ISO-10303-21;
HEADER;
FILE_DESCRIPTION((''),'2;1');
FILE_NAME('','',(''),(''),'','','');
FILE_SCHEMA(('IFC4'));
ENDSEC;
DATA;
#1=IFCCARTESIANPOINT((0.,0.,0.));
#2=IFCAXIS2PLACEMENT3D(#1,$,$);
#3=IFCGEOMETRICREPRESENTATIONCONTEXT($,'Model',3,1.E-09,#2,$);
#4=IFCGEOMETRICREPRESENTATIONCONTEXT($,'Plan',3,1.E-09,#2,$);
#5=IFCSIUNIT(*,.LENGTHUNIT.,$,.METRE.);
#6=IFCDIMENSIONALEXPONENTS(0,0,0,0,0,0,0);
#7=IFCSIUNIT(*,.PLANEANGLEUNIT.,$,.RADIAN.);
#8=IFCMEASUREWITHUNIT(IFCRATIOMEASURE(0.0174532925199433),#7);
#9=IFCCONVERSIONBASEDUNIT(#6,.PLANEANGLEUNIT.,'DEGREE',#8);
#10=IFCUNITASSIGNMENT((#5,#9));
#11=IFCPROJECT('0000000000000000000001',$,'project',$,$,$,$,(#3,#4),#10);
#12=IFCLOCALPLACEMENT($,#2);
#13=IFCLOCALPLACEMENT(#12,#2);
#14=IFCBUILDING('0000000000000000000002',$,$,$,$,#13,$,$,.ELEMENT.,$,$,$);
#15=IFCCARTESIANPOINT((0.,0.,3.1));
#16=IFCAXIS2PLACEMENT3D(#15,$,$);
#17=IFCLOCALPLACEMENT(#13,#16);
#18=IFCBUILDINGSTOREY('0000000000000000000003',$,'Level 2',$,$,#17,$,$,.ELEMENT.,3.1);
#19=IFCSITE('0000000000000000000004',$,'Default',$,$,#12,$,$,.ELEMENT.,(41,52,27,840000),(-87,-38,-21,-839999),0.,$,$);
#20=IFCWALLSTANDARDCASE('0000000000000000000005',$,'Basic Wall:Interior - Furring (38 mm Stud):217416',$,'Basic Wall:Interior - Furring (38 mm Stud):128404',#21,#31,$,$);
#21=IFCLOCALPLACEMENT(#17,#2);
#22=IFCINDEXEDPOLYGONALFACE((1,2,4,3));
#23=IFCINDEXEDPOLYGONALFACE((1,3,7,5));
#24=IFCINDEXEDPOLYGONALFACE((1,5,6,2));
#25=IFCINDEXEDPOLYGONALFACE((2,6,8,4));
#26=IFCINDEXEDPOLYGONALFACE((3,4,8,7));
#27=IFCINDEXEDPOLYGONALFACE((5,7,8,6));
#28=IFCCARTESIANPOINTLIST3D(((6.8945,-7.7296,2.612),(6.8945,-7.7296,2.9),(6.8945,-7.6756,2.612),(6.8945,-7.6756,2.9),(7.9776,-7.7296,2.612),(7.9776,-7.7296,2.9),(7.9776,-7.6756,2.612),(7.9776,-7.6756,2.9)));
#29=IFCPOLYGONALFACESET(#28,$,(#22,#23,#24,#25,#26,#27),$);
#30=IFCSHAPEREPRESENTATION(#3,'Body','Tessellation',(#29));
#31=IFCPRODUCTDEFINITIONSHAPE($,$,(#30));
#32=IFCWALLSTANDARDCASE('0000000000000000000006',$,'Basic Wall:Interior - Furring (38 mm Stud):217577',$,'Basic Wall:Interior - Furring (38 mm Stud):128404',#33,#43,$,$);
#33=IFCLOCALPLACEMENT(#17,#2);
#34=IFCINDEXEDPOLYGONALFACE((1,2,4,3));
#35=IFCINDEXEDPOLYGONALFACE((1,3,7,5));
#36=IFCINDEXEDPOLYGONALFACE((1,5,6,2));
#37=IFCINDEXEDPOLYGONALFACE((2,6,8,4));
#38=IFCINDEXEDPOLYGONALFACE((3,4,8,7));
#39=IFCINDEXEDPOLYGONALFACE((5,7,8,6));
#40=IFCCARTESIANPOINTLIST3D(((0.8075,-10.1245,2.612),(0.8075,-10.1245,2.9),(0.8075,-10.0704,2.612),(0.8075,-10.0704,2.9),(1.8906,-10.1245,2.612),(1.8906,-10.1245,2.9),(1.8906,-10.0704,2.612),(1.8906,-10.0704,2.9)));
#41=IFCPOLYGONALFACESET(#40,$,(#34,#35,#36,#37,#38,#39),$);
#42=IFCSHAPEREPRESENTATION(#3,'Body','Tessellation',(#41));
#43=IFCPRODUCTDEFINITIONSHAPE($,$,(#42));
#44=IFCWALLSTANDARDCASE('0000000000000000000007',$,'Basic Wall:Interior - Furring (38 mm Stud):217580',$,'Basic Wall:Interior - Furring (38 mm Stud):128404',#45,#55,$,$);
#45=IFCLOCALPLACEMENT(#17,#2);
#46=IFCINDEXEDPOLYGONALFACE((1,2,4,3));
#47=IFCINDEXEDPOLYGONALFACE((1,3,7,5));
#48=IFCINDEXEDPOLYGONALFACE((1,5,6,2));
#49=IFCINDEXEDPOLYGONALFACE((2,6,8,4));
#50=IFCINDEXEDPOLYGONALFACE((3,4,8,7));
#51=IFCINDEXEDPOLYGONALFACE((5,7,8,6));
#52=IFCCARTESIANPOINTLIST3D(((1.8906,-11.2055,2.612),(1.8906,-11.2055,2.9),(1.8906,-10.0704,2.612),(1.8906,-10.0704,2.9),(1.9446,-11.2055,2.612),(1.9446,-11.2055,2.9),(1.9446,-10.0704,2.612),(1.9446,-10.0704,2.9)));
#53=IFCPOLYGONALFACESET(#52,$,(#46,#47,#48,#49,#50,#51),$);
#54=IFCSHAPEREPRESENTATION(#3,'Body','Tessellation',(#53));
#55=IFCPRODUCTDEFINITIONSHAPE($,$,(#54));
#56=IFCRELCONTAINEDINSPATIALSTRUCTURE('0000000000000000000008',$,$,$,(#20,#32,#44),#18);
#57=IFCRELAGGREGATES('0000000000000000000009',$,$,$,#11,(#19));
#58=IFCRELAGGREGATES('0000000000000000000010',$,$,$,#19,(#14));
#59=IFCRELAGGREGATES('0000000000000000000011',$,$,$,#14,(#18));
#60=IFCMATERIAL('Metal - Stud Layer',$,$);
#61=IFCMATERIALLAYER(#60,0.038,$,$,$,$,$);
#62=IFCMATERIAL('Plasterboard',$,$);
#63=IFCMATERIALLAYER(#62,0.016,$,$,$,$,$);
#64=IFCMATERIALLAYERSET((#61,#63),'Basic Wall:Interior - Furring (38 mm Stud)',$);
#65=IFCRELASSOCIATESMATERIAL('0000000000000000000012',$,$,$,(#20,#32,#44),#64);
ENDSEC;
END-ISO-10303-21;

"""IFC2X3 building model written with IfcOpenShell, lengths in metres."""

from ifc_helpers import new_model, entity, si_unit, converted_unit, frame, frame_2d, origin, place, context, project, spatial, rectangle, extrude, material, layer, layer_set, layer_usage, element, save


model = new_model("IFC2X3")

# Units and contexts
model_context = context("Model", 3, precision=1e-09, world=origin())
plan_context = context("Plan", 3, precision=1e-09, world=origin())
ifc_project = project(units=[si_unit("LENGTHUNIT", "METRE"), converted_unit("PLANEANGLEUNIT", "DEGREE", entity("IfcRatioMeasure", 0.0174532925199433), si_unit("PLANEANGLEUNIT", "RADIAN"), dimensions=[0, 0, 0, 0, 0, 0, 0])], contexts=[model_context, plan_context])

# Site, building, storey
site_placement = place(None, origin())
site = spatial("IfcSite", under=ifc_project, at=site_placement, Name="Default", CompositionType="ELEMENT", RefLatitude=(41, 52, 27, 840000), RefLongitude=(-87, -38, -21, -839999), RefElevation=0.0)
building_placement = place(site_placement, origin())
building = spatial("IfcBuilding", under=site, at=building_placement, CompositionType="ELEMENT")
storey_placement = place(building_placement, frame((0.0, 0.0, 3.1)))
storey = spatial("IfcBuildingStorey", under=building, at=storey_placement, Name="Level 2", CompositionType="ELEMENT", Elevation=3.1)

# Shared definitions
ifc_material_1 = material(Name="Plasterboard")
ifc_material_2 = material(Name="Metal - Stud Layer")

# Walls
ifc_layer_1 = layer(ifc_material_2, 0.038)
ifc_layer_2 = layer(ifc_material_1, 0.016)
ifc_layer_set_1 = layer_set([ifc_layer_1, ifc_layer_2], Name="Basic Wall:Interior - Furring (38 mm Stud)")
ifc_layer_usage_1 = layer_usage(ifc_layer_set_1, "AXIS2", "NEGATIVE", 0.027)
wall_1_placement = place(storey_placement, frame((7.9776, -7.7026, 2.612), z_axis=(0.0, 0.0, 1.0), x_axis=(-1.0, 0.0, 0.0)))
element("IfcWallStandardCase", 1, at=wall_1_placement, inside=storey, material=ifc_layer_usage_1, Name="Basic Wall:Interior - Furring (38 mm Stud):217416", ObjectType="Basic Wall:Interior - Furring (38 mm Stud):128404", context=model_context, shape_type="SweptSolid", body=[
    extrude(rectangle(XDim=1.0831, YDim=0.054, at=frame_2d((0.5415, 0.0), x_axis=(-1.0, 0.0))), origin(), (0.0, 0.0, 1.0), 0.288),
])
ifc_layer_usage_2 = layer_usage(ifc_layer_set_1, "AXIS2", "NEGATIVE", 0.027)
wall_2_placement = place(storey_placement, frame((0.8075, -10.0975, 2.612)))
element("IfcWallStandardCase", 2, at=wall_2_placement, inside=storey, material=ifc_layer_usage_2, Name="Basic Wall:Interior - Furring (38 mm Stud):217577", ObjectType="Basic Wall:Interior - Furring (38 mm Stud):128404", context=model_context, shape_type="SweptSolid", body=[
    extrude(rectangle(XDim=1.0831, YDim=0.054, at=frame_2d((0.5415, 0.0), x_axis=(-1.0, 0.0))), origin(), (0.0, 0.0, 1.0), 0.288),
])
ifc_layer_usage_3 = layer_usage(ifc_layer_set_1, "AXIS2", "NEGATIVE", 0.027)
wall_3_placement = place(storey_placement, frame((1.9176, -10.0704, 2.612), z_axis=(0.0, 0.0, 1.0), x_axis=(0.0, -1.0, 0.0)))
element("IfcWallStandardCase", 3, at=wall_3_placement, inside=storey, material=ifc_layer_usage_3, Name="Basic Wall:Interior - Furring (38 mm Stud):217580", ObjectType="Basic Wall:Interior - Furring (38 mm Stud):128404", context=model_context, shape_type="SweptSolid", body=[
    extrude(rectangle(XDim=1.1351, YDim=0.054, at=frame_2d((0.5675, 0.0), x_axis=(-1.0, 0.0))), origin(), (0.0, 0.0, 1.0), 0.288),
])

save(model, "model.ifc")
